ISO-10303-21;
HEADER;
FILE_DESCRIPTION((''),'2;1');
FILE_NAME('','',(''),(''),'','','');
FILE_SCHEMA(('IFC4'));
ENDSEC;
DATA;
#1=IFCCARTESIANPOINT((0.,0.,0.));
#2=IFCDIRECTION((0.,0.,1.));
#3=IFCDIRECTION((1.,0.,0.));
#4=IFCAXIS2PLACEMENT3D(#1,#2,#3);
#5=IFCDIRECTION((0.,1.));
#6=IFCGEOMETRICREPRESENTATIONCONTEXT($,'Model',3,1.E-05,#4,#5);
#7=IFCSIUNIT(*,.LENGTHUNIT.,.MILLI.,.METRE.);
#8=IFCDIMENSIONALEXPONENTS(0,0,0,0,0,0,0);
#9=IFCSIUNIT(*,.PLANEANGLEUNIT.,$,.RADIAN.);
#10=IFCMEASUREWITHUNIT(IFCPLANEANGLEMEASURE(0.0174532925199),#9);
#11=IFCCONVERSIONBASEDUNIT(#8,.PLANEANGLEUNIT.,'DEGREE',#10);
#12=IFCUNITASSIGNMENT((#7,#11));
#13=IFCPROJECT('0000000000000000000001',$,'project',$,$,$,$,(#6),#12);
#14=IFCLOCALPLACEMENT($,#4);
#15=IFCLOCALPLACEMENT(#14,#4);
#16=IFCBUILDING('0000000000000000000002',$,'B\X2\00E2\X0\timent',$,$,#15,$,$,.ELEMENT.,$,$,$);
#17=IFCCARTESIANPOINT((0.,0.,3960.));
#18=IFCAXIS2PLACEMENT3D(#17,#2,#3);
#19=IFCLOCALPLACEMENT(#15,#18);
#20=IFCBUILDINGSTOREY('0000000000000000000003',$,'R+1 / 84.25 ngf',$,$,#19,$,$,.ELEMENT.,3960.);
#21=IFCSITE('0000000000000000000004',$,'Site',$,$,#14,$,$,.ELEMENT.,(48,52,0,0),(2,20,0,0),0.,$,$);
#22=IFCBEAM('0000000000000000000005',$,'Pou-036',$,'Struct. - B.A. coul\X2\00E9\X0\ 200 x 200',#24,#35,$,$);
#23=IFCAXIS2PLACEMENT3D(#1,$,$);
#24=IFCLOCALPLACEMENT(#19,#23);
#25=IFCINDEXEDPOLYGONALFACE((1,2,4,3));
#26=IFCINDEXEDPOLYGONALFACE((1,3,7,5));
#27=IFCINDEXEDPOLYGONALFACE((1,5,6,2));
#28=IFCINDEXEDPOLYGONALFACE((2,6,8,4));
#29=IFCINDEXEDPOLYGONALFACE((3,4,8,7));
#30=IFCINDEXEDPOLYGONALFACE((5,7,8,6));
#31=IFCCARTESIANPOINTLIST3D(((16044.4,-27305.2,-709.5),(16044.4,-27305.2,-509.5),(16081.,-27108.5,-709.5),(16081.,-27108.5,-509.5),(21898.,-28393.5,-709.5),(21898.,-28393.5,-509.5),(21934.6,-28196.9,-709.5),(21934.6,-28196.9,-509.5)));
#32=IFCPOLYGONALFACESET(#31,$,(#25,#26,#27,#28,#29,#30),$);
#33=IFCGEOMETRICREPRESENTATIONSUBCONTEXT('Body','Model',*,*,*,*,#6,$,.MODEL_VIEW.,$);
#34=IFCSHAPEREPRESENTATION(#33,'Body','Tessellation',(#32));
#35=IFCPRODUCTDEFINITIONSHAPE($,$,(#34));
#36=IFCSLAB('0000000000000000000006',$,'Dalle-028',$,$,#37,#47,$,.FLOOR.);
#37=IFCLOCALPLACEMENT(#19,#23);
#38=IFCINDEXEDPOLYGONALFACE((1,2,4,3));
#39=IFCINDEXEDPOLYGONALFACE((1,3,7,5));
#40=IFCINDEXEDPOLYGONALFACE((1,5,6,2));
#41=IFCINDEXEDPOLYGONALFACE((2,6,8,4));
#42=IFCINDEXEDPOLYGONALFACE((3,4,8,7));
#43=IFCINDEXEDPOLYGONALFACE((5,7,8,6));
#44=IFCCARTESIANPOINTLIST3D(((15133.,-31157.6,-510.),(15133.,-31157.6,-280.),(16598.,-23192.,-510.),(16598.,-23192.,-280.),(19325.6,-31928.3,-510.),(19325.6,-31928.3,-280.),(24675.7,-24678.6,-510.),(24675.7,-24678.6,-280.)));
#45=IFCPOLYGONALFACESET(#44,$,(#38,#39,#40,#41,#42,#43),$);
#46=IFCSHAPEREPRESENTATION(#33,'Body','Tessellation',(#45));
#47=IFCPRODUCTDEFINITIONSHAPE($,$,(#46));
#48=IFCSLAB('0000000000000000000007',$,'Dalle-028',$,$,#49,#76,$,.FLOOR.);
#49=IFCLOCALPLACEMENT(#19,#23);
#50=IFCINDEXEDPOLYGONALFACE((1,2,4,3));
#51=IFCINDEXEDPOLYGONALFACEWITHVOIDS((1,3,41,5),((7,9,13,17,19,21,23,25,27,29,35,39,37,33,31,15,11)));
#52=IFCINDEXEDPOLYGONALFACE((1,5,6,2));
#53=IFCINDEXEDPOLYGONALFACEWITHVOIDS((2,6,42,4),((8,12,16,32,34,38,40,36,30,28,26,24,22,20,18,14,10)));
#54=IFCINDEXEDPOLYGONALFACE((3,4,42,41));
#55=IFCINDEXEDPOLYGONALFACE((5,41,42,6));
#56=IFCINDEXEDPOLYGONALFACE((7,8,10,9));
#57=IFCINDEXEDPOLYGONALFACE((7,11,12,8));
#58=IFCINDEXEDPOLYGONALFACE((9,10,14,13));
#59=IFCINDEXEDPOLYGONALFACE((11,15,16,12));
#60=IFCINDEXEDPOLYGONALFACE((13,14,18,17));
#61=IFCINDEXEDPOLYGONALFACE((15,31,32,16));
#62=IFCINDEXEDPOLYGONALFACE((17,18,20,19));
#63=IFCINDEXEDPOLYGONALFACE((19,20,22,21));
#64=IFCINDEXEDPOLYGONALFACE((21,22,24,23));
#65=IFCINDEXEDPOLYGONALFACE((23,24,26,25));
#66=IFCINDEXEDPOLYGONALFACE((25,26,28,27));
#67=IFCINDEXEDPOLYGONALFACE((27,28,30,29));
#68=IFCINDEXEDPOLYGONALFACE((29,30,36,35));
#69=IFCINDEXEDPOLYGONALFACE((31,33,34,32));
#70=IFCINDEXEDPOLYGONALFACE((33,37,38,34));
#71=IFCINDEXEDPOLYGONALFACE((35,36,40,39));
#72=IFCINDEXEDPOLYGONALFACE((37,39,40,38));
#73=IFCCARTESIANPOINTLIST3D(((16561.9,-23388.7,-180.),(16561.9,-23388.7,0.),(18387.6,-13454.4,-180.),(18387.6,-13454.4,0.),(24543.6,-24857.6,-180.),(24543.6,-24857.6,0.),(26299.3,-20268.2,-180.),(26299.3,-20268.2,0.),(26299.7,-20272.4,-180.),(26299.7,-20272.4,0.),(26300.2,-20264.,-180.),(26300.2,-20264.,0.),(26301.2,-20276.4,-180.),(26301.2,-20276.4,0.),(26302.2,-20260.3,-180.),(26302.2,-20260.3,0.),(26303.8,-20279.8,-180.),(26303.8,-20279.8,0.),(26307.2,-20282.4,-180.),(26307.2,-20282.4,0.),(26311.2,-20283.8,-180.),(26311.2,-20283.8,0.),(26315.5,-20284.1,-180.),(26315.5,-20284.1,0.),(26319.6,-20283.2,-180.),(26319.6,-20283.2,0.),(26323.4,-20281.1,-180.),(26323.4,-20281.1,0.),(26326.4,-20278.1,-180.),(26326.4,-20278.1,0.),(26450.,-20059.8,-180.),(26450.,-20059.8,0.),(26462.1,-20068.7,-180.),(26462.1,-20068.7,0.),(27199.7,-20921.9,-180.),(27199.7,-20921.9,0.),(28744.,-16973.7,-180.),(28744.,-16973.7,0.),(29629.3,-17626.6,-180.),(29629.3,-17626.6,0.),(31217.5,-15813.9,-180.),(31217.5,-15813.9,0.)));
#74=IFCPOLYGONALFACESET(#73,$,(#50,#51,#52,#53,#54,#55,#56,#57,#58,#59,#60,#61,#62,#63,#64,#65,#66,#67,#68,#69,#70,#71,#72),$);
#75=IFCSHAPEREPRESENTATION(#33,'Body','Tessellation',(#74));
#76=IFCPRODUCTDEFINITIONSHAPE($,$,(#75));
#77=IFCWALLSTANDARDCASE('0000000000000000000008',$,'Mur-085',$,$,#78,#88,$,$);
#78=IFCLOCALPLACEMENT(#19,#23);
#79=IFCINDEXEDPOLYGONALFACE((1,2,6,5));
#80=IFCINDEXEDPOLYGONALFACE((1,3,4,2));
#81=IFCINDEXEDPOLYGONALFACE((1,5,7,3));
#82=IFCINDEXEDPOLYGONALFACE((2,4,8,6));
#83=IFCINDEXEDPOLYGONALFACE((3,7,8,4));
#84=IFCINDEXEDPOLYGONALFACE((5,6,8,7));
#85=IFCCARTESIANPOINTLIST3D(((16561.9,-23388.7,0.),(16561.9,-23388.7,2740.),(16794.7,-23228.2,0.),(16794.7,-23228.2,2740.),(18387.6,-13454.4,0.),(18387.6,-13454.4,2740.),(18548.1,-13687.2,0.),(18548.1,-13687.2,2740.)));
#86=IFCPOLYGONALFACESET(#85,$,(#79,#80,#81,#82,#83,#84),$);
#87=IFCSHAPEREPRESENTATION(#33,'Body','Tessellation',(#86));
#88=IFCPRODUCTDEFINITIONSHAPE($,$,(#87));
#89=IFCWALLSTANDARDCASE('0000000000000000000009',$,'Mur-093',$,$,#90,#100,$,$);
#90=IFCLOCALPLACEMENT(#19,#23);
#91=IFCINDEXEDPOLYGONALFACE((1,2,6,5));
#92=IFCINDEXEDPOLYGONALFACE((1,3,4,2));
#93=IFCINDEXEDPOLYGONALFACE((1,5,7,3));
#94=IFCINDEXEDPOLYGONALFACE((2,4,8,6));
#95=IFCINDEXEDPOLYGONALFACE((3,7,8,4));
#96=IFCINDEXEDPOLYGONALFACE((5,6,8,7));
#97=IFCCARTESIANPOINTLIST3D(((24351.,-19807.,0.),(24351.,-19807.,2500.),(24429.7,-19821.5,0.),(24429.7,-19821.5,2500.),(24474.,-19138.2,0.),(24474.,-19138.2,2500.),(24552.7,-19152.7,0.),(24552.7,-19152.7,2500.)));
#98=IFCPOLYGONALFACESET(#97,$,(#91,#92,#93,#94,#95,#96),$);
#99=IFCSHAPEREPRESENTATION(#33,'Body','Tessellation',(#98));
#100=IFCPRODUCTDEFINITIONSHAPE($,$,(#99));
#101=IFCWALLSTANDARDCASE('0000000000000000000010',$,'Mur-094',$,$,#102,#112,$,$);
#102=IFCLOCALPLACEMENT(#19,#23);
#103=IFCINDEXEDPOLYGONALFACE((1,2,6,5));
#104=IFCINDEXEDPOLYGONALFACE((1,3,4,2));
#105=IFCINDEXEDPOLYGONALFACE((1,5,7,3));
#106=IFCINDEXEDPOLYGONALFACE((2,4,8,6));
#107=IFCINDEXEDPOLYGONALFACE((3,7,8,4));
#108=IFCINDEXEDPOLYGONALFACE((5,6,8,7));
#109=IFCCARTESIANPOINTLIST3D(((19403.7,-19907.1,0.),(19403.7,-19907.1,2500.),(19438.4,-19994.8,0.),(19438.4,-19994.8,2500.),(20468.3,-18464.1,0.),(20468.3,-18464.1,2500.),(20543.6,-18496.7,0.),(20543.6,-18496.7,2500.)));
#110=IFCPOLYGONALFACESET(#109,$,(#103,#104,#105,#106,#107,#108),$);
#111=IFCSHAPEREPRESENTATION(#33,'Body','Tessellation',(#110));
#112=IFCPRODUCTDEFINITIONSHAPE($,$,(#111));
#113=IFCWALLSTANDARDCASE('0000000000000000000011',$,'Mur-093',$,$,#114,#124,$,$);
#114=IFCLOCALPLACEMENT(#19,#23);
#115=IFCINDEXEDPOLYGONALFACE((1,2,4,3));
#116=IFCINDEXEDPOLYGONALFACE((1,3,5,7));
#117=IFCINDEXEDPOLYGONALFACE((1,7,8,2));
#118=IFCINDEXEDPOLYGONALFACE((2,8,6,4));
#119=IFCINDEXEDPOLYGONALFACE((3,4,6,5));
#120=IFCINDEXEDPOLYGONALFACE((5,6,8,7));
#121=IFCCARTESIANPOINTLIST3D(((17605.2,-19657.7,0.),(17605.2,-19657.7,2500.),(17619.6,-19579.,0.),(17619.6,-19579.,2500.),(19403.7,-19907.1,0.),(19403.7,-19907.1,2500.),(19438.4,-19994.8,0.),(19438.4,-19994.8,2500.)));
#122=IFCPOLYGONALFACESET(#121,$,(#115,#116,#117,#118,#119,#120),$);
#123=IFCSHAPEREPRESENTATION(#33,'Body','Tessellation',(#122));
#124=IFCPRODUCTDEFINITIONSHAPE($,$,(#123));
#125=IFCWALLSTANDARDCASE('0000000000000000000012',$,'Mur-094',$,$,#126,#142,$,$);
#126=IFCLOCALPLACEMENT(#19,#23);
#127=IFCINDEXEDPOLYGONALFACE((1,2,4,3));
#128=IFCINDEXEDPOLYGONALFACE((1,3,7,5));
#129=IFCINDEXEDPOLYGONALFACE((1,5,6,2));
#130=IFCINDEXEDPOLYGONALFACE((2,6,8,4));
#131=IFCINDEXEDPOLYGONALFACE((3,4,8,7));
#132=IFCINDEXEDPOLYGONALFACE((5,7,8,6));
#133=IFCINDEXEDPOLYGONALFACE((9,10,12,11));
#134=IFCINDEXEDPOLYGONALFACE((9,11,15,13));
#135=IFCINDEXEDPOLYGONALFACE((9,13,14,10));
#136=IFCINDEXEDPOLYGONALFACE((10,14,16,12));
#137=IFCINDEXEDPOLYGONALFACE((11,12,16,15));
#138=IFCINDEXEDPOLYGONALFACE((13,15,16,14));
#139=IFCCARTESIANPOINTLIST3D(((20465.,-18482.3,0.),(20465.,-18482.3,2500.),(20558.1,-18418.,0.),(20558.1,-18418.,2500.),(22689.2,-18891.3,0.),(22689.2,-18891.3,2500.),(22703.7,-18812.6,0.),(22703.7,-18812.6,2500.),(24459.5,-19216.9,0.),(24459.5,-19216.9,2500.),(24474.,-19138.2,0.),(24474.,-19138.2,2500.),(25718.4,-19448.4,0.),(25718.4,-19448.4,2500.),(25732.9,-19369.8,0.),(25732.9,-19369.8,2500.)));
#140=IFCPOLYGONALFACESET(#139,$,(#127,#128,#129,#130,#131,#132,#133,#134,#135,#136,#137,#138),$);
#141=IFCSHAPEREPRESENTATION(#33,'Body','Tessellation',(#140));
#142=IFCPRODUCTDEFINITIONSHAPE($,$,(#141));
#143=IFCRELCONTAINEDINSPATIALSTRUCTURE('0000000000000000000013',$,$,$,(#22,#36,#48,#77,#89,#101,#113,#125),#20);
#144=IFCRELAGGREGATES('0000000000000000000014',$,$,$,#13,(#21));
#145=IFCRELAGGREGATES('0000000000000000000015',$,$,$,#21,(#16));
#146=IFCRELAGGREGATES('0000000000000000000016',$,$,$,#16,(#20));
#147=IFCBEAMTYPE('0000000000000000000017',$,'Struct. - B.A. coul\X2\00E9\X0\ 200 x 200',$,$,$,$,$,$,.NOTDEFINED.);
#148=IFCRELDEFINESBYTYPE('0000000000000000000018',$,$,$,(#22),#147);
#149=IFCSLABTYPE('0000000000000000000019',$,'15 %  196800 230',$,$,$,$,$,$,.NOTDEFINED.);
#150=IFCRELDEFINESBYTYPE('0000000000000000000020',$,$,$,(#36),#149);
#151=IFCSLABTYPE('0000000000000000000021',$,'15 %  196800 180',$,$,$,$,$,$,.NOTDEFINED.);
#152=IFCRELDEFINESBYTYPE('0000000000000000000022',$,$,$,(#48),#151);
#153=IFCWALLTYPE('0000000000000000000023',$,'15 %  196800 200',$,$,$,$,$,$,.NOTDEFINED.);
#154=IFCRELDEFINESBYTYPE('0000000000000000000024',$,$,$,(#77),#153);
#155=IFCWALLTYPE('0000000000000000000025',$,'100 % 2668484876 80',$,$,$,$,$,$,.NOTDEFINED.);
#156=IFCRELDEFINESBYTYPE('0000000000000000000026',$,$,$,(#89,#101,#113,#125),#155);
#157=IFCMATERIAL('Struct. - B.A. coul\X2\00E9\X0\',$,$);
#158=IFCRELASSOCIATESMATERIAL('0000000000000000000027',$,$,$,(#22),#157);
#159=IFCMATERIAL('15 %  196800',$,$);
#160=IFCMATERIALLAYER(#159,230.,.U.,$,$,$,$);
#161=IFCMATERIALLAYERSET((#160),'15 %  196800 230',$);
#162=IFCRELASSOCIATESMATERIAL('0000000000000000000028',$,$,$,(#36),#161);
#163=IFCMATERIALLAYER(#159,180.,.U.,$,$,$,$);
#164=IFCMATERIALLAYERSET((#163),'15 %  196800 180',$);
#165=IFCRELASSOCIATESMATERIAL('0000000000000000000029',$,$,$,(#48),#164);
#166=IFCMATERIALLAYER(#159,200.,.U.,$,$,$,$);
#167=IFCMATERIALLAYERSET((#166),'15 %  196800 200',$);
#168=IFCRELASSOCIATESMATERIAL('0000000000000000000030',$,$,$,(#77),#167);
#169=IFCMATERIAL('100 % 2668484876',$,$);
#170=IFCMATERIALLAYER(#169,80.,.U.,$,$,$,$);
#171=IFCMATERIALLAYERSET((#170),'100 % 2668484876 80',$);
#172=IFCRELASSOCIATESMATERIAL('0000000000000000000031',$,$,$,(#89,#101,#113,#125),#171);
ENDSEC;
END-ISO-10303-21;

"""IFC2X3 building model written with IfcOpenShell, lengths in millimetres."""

from ifc_helpers import new_model, entity, si_unit, converted_unit, point, direction, frame, frame_2d, origin_with_axes, origin_2d_with_axis, place, context, subcontext, project, spatial, polyline, circle_curve, parameter, trimmed, segment, composite_curve, rectangle, outline, extrude, material, layer, layer_set, layer_usage, type_object, element, save


model = new_model("IFC2X3")

# Units and contexts
model_context = context("Model", 3, precision=1e-05, world=origin_with_axes(), true_north=direction((0.0, 1.0)))
body_context = subcontext(model_context, "Body", "Model", "MODEL_VIEW")
ifc_project = project(units=[si_unit("LENGTHUNIT", "METRE", prefix="MILLI"), converted_unit("PLANEANGLEUNIT", "DEGREE", entity("IfcPlaneAngleMeasure", 0.0174532925199), si_unit("PLANEANGLEUNIT", "RADIAN"), dimensions=[0, 0, 0, 0, 0, 0, 0])], contexts=[model_context])

# Site, building, storey
site_placement = place(None, origin_with_axes())
site = spatial("IfcSite", under=ifc_project, at=site_placement, Name="Site", CompositionType="ELEMENT", RefLatitude=(48, 52, 0, 0), RefLongitude=(2, 20, 0, 0), RefElevation=0.0)
building_placement = place(site_placement, origin_with_axes())
building = spatial("IfcBuilding", under=site, at=building_placement, Name="Bâtiment", CompositionType="ELEMENT")
storey_placement = place(building_placement, frame((0.0, 0.0, 3960.0), z_axis=(0.0, 0.0, 1.0), x_axis=(1.0, 0.0, 0.0)))
storey = spatial("IfcBuildingStorey", under=building, at=storey_placement, Name="R+1 / 84.25 ngf", CompositionType="ELEMENT", Elevation=3960.0)

# Beam
ifc_material_1 = material(Name="Struct. - B.A. coulé")
beam_type = type_object("IfcBeamType", Name="Struct. - B.A. coulé 200 x 200", PredefinedType="NOTDEFINED")
beam_placement = place(storey_placement, frame((16062.7, -27206.8, -509.5), z_axis=(0.0, 0.0, 1.0), x_axis=(-0.1828, -0.98315, 0.0)))
element("IfcBeam", 1, at=beam_placement, inside=storey, type_object=beam_type, material=ifc_material_1, Name="Pou-036", ObjectType="Struct. - B.A. coulé 200 x 200", context=body_context, shape_type="SweptSolid", body=[
    extrude(rectangle(XDim=200.0, YDim=200.0, at=frame_2d((-100.0, 0.0), x_axis=(1.0, 0.0))), frame((0.0, 0.0, 0.0), z_axis=(0.0, 1.0, 0.0), x_axis=(0.0, 0.0, 1.0)), (0.0, 0.0, 1.0), 5954.0),
])

# Slab
ifc_material_2 = material(Name="15 %  196800")
ifc_layer_1 = layer(ifc_material_2, 230.0, ventilated="UNKNOWN")
ifc_layer_set_1 = layer_set([ifc_layer_1], Name="15 %  196800 230")
ifc_layer_usage_1 = layer_usage(ifc_layer_set_1, "AXIS3", "NEGATIVE", 230.0)
slab_type_1 = type_object("IfcSlabType", Name="15 %  196800 230", PredefinedType="NOTDEFINED")
slab_1_placement = place(storey_placement, frame((16598.0, -23192.0, -280.0), z_axis=(0.0, 0.0, 1.0), x_axis=(1.0, 0.0, 0.0)))
element("IfcSlab", 2, at=slab_1_placement, inside=storey, type_object=slab_type_1, material=ifc_layer_usage_1, Name="Dalle-028", PredefinedType="FLOOR", context=body_context, shape_type="SweptSolid", body=[
    extrude(outline(polyline([(0.0, 0.0), (-1465.0, -7965.6), (2727.6, -8736.3), (8077.7, -1486.6), (0.0, 0.0)])), frame((0.0, 0.0, -230.0), z_axis=(0.0, 0.0, 1.0), x_axis=(1.0, 0.0, 0.0)), (0.0, 0.0, 1.0), 230.0),
])

# Slab, opening
ifc_layer_2 = layer(ifc_material_2, 180.0, ventilated="UNKNOWN")
ifc_layer_set_2 = layer_set([ifc_layer_2], Name="15 %  196800 180")
ifc_layer_usage_2 = layer_usage(ifc_layer_set_2, "AXIS3", "NEGATIVE", 180.0)
slab_type_2 = type_object("IfcSlabType", Name="15 %  196800 180", PredefinedType="NOTDEFINED")
slab_2_placement = place(storey_placement, frame((18387.6, -13454.4, 0.0), z_axis=(0.0, 0.0, 1.0), x_axis=(1.0, 0.0, 0.0)))
slab_2 = element("IfcSlab", 3, at=slab_2_placement, inside=storey, type_object=slab_type_2, material=ifc_layer_usage_2, Name="Dalle-028", PredefinedType="FLOOR", context=body_context, shape_type="SweptSolid", body=[
    extrude(outline(polyline([(0.0, 0.0), (-1825.7, -9934.4), (6156.0, -11403.3), (12829.9, -2359.6), (0.0, 0.0)])), frame((0.0, 0.0, -180.0), z_axis=(0.0, 0.0, 1.0), x_axis=(1.0, 0.0, 0.0)), (0.0, 0.0, 1.0), 180.0),
])
opening_1_placement = place(slab_2_placement, origin_with_axes())
element("IfcOpeningElement", 4, at=opening_1_placement, cuts=slab_2, context=body_context, shape_type="SweptSolid", body=[
    extrude(outline(composite_curve([segment(polyline([(7938.8, -6823.7), (8812.1, -7467.6), (11241.7, -4172.3), (10356.4, -3519.4), (8074.5, -6614.3), (8062.5, -6605.4), (7914.6, -6805.9)]), True, "CONTINUOUS"), segment(trimmed(circle_curve(frame_2d((7926.7, -6814.8), x_axis=(-0.80488, 0.593437)), 15.0), [point((7914.6, -6805.9)), parameter(0.0)], [point((7938.8, -6823.7)), parameter(179.934715)], True, "CARTESIAN"), True, "CONTINUOUS")], self_intersect=False)), frame((0.0, 0.0, -180.0), z_axis=(0.0, 0.0, 1.0), x_axis=(1.0, 0.0, 0.0)), (0.0, 0.0, 1.0), 180.0),
])

# Shared definitions
ifc_layer_3 = layer(ifc_material_2, 200.0, ventilated="UNKNOWN")
ifc_layer_set_3 = layer_set([ifc_layer_3], Name="15 %  196800 200")
wall_type_1 = type_object("IfcWallType", Name="15 %  196800 200", PredefinedType="NOTDEFINED")

# Walls
ifc_layer_usage_3 = layer_usage(ifc_layer_set_3, "AXIS2", "NEGATIVE", 0.0)
wall_1_placement = place(storey_placement, frame((16561.9, -23388.7, 0.0), z_axis=(0.0, 0.0, 1.0), x_axis=(0.18075, 0.983529, 0.0)))
element("IfcWallStandardCase", 5, at=wall_1_placement, inside=storey, type_object=wall_type_1, material=ifc_layer_usage_3, Name="Mur-085", context=body_context, shape_type="SweptSolid", body=[
    extrude(outline(polyline([(199.9, -200.0), (9900.7, -200.0), (10100.7, 0.0), (0.0, 0.0), (199.9, -200.0)])), origin_with_axes(), (0.0, 0.0, 1.0), 2740.0),
])
ifc_material_3 = material(Name="100 % 2668484876")
ifc_layer_4 = layer(ifc_material_3, 80.0, ventilated="UNKNOWN")
ifc_layer_set_4 = layer_set([ifc_layer_4], Name="100 % 2668484876 80")
wall_type_2 = type_object("IfcWallType", Name="100 % 2668484876 80", PredefinedType="NOTDEFINED")
ifc_layer_usage_4 = layer_usage(ifc_layer_set_4, "AXIS2", "POSITIVE", -80.0)
wall_2_placement = place(storey_placement, frame((24552.7, -19152.7, 0.0), z_axis=(0.0, 0.0, 1.0), x_axis=(-0.180879, -0.983505, 0.0)))
element("IfcWallStandardCase", 6, at=wall_2_placement, inside=storey, type_object=wall_type_2, material=ifc_layer_usage_4, Name="Mur-093", context=body_context, shape_type="SweptSolid", body=[
    extrude(outline(polyline([(0.0, -80.0), (680.0, -80.0), (680.0, 0.0), (0.0, 0.0), (0.0, -80.0)])), origin_with_axes(), (0.0, 0.0, 1.0), 2500.0),
])
ifc_layer_usage_5 = layer_usage(ifc_layer_set_4, "AXIS2", "POSITIVE", -80.0)
wall_3_placement = place(storey_placement, frame((20543.6, -18496.7, 0.0), z_axis=(0.0, 0.0, 1.0), x_axis=(-0.593676, -0.804704, 0.0)))
element("IfcWallStandardCase", 7, at=wall_3_placement, inside=storey, type_object=wall_type_2, material=ifc_layer_usage_5, Name="Mur-094", context=body_context, shape_type="SweptSolid", body=[
    extrude(outline(polyline([(18.5, -80.0), (1811.7, -80.0), (1861.7, 0.0), (0.0, 0.0), (18.5, -80.0)])), origin_with_axes(), (0.0, 0.0, 1.0), 2500.0),
])
ifc_layer_usage_6 = layer_usage(ifc_layer_set_4, "AXIS2", "NEGATIVE", 80.0)
wall_4_placement = place(storey_placement, frame((17605.2, -19657.7, 0.0), z_axis=(0.0, 0.0, 1.0), x_axis=(0.983505, -0.180879, 0.0)))
element("IfcWallStandardCase", 8, at=wall_4_placement, inside=storey, type_object=wall_type_2, material=ifc_layer_usage_6, Name="Mur-093", context=body_context, shape_type="SweptSolid", body=[
    extrude(outline(polyline([(0.0, 0.0), (1864.0, 0.0), (1814.0, 80.0), (0.0, 80.0), (0.0, 0.0)])), origin_with_axes(), (0.0, 0.0, 1.0), 2500.0),
])

# Wall, opening
ifc_layer_usage_7 = layer_usage(ifc_layer_set_4, "AXIS2", "NEGATIVE", 80.0)
wall_5_placement = place(storey_placement, frame((20543.6, -18496.7, 0.0), z_axis=(0.0, 0.0, 1.0), x_axis=(0.983505, -0.180879, 0.0)))
wall_5 = element("IfcWallStandardCase", 9, at=wall_5_placement, inside=storey, type_object=wall_type_2, material=ifc_layer_usage_7, Name="Mur-094", context=body_context, shape_type="SweptSolid", body=[
    extrude(outline(polyline([(-80.0, 0.0), (5261.5, 0.0), (5261.5, 80.0), (0.0, 80.0), (-80.0, 0.0)])), origin_with_axes(), (0.0, 0.0, 1.0), 2500.0),
])
opening_2_placement = place(wall_5_placement, frame((3081.5, 0.0, 0.0), z_axis=(0.0, 0.0, 1.0), x_axis=(1.0, 0.0, 0.0)))
element("IfcOpeningElement", 10, at=opening_2_placement, cuts=wall_5, context=body_context, shape_type="SweptSolid", body=[
    extrude(rectangle(XDim=1800.0, YDim=2500.0, at=origin_2d_with_axis()), frame((0.0, -80.0, 1250.0), z_axis=(0.0, -1.0, 0.0), x_axis=(1.0, 0.0, 0.0)), (0.0, 0.0, -1.0), 240.0),
])

save(model, "model.ifc")
